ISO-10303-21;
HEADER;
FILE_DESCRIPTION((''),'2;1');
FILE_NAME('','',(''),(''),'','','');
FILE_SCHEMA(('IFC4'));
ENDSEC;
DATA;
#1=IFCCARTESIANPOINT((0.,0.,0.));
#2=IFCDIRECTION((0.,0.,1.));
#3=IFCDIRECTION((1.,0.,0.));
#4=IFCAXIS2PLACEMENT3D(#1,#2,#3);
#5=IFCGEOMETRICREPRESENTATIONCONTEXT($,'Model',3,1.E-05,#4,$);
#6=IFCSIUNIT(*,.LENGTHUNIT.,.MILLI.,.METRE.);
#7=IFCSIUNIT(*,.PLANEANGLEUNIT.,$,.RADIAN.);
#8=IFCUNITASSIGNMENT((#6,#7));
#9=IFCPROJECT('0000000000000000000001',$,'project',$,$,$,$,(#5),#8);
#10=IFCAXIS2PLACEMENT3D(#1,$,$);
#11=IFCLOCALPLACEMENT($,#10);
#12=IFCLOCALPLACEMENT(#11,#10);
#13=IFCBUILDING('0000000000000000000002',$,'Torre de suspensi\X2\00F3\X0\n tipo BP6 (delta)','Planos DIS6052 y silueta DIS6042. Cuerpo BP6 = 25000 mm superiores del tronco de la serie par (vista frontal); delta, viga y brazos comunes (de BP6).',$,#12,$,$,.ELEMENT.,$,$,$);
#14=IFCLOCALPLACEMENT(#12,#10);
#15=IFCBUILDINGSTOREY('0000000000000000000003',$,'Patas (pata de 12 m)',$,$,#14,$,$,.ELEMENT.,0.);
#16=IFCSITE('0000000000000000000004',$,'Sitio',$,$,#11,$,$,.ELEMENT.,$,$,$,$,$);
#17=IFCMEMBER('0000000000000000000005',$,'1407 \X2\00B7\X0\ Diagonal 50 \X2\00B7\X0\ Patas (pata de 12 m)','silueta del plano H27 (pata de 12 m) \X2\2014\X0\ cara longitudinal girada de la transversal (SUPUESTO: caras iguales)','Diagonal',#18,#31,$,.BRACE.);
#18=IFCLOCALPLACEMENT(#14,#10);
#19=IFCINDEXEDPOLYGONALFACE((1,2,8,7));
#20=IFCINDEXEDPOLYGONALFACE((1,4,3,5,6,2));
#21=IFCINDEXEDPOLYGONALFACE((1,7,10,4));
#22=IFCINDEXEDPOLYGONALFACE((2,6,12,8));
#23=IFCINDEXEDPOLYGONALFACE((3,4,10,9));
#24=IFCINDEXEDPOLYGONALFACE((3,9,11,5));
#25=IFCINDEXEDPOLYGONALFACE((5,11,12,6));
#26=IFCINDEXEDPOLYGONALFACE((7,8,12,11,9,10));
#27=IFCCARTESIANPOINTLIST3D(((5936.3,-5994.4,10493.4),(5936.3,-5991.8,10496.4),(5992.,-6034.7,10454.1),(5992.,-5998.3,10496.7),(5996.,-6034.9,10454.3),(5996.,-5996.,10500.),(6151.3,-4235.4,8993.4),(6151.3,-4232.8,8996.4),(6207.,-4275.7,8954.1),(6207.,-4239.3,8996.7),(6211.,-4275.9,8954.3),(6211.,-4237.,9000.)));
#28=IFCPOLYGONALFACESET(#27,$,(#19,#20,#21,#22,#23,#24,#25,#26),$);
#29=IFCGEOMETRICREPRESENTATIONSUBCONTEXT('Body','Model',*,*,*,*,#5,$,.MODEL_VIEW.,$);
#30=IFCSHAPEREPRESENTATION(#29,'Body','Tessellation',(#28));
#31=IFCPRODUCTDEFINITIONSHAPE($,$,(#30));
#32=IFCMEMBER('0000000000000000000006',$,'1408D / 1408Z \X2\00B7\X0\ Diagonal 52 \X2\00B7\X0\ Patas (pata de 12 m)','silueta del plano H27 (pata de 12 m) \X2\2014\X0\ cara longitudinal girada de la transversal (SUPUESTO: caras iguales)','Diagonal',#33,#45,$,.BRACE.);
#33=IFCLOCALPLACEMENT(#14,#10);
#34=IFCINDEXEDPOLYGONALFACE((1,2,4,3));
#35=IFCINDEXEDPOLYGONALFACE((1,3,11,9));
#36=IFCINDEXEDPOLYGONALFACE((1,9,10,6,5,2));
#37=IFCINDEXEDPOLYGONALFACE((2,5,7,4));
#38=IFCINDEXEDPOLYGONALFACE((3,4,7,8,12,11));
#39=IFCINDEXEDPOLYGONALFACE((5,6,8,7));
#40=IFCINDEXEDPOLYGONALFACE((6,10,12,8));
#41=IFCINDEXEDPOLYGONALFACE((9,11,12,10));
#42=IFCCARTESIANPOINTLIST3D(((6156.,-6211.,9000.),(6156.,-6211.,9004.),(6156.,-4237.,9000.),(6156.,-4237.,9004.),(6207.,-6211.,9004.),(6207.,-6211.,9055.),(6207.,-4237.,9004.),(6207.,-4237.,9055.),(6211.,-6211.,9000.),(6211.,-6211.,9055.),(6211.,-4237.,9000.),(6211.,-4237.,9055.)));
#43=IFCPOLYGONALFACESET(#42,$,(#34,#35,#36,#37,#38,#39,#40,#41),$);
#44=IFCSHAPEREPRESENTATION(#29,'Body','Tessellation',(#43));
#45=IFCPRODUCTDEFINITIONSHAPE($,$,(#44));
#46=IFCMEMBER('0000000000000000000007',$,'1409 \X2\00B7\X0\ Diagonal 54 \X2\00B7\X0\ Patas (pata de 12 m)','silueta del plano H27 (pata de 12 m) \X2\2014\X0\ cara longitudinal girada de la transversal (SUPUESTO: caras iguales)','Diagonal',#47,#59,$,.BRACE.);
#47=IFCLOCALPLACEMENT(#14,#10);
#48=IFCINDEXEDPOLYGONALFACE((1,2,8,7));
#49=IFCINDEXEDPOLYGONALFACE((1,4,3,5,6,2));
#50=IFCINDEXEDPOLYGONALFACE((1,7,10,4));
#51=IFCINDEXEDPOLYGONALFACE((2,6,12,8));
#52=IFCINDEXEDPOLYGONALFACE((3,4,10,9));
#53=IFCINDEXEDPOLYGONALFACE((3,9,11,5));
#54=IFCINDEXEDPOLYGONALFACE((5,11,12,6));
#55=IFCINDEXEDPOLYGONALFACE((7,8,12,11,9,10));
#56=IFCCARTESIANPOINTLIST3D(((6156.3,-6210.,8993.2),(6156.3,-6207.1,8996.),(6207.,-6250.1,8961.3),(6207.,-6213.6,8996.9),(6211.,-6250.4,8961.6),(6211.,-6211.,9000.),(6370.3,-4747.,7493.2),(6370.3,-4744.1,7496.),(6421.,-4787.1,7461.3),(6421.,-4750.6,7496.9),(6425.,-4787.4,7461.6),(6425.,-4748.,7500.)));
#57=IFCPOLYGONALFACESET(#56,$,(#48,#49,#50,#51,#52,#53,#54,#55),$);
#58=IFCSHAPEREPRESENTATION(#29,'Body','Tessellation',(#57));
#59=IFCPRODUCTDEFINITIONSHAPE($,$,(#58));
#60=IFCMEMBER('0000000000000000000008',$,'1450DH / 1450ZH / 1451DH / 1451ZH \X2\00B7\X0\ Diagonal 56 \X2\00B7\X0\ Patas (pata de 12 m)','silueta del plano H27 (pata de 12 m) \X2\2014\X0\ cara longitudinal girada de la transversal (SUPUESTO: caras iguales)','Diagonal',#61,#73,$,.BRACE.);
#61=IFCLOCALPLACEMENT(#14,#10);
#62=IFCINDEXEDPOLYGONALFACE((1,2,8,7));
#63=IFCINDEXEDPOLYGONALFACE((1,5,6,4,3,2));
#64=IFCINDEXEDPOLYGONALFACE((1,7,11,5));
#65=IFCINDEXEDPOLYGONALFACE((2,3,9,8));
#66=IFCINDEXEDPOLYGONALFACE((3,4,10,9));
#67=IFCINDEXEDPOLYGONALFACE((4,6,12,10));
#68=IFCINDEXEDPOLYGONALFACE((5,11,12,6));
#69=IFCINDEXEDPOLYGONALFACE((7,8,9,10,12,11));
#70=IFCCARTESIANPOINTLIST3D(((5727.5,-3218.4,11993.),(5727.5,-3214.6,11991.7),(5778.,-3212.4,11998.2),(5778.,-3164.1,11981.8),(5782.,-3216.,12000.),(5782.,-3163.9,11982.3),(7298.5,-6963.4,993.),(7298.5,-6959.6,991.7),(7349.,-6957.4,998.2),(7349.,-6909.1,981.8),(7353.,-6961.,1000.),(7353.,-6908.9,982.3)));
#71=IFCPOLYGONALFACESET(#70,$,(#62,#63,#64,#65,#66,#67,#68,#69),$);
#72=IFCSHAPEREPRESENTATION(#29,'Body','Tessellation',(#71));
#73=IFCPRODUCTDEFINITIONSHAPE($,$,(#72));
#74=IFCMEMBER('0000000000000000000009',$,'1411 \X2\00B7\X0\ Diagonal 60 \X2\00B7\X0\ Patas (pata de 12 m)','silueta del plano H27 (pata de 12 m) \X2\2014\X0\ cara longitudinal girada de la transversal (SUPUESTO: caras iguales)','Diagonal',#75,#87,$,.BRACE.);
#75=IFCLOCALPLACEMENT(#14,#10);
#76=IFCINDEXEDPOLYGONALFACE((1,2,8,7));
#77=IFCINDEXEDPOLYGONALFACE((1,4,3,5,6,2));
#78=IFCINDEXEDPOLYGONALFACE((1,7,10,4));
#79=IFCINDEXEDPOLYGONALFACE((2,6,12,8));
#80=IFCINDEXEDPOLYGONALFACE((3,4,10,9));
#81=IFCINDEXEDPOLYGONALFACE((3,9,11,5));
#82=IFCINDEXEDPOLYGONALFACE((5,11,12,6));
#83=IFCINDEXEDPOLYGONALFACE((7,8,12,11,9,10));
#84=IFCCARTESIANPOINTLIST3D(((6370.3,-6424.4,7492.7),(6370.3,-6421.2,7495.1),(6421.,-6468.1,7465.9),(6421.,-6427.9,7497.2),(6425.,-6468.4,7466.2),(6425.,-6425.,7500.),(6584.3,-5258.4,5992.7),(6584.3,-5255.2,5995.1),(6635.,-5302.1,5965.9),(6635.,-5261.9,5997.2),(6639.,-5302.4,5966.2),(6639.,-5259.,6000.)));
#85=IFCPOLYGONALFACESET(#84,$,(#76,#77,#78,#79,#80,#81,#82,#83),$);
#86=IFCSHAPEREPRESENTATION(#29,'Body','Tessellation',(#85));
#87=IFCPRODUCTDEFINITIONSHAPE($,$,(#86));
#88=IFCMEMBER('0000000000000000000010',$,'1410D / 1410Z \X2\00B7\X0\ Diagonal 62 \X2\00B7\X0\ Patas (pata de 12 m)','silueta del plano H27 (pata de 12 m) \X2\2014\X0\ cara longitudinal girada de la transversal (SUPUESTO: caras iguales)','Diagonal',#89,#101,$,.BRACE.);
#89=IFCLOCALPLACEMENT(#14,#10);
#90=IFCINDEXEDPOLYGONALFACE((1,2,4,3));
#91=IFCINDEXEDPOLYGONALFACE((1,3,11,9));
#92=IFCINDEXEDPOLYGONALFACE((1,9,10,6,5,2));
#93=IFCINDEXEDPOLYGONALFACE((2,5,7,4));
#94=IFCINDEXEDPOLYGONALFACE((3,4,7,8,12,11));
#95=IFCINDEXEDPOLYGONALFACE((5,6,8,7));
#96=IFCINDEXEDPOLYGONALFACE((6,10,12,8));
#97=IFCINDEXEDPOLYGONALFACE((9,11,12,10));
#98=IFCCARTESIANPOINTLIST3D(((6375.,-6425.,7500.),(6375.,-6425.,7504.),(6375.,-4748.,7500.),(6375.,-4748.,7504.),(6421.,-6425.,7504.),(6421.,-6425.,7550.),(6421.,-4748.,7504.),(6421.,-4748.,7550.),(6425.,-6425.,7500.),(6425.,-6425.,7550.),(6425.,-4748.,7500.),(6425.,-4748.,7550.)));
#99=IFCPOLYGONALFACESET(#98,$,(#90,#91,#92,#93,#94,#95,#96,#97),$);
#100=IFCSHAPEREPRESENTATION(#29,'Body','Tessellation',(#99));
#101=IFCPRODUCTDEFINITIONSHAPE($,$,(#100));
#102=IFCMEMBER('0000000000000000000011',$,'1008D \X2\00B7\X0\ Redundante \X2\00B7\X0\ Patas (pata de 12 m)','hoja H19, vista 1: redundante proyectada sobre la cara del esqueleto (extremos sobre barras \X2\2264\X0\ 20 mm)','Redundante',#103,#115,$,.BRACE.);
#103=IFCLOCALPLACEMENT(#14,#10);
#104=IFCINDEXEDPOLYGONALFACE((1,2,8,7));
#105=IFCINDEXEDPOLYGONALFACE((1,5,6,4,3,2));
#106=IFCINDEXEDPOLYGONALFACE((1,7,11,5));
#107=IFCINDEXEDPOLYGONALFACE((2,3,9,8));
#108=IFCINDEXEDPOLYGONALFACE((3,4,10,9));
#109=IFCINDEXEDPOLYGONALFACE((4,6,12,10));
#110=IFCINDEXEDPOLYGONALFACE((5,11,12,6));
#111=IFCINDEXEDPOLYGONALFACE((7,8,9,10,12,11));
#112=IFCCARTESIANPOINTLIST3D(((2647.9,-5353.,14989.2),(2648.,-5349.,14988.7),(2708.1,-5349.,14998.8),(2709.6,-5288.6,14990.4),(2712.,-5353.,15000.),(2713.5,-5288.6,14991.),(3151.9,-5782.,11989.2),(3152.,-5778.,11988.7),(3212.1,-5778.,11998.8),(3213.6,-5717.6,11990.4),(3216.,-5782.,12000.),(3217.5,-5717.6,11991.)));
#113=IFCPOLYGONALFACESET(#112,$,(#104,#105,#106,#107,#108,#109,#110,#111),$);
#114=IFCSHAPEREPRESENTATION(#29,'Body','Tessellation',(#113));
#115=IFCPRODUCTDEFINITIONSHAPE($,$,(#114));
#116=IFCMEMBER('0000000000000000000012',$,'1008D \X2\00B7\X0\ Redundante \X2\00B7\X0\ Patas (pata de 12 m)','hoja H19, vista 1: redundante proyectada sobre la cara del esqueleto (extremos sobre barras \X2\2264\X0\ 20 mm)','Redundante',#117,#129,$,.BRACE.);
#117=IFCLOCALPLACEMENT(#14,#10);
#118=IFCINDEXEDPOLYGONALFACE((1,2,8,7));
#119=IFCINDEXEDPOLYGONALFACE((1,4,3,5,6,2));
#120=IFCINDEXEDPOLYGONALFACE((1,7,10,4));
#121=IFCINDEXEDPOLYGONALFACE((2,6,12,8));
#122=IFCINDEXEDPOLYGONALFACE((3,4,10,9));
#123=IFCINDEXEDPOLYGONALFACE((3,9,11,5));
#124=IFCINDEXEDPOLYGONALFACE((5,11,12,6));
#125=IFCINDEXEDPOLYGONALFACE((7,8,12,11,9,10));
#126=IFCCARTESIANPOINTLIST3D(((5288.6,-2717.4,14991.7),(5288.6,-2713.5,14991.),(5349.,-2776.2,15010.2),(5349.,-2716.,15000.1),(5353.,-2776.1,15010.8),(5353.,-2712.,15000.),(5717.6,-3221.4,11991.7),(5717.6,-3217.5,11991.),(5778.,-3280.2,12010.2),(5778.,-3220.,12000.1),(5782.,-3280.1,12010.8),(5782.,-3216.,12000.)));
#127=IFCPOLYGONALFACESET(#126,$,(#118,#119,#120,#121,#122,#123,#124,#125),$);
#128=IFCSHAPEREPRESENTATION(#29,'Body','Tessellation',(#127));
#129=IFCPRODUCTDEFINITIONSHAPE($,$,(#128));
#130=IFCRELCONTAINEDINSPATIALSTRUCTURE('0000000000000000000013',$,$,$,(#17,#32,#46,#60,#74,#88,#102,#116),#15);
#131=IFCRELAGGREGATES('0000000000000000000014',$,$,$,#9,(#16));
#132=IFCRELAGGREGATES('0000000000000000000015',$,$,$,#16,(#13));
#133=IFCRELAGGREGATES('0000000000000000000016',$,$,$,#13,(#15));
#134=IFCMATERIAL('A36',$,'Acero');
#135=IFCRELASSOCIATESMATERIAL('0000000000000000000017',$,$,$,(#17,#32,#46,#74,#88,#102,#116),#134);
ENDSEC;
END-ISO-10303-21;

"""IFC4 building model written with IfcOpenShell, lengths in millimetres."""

from ifc_helpers import new_model, si_unit, frame, frame_2d, origin, origin_with_axes, place, context, subcontext, project, spatial, l_section, extrude, material, element, save


model = new_model("IFC4")

# Units and contexts
model_context = context("Model", 3, precision=1e-05, world=origin_with_axes())
body_context = subcontext(model_context, "Body", "Model", "MODEL_VIEW")
ifc_project = project(units=[si_unit("LENGTHUNIT", "METRE", prefix="MILLI"), si_unit("PLANEANGLEUNIT", "RADIAN")], contexts=[model_context])

# Site, building, storey
site_placement = place(None, origin())
site = spatial("IfcSite", under=ifc_project, at=site_placement, Name="Sitio", CompositionType="ELEMENT")
building_placement = place(site_placement, origin())
building = spatial("IfcBuilding", under=site, at=building_placement, Name="Torre de suspensión tipo BP6 (delta)", Description="Planos DIS6052 y silueta DIS6042. Cuerpo BP6 = 25000 mm superiores del tronco de la serie par (vista frontal); delta, viga y brazos comunes (de BP6).", CompositionType="ELEMENT")
storey_placement = place(building_placement, origin())
storey = spatial("IfcBuildingStorey", under=building, at=storey_placement, Name="Patas (pata de 12 m)", CompositionType="ELEMENT", Elevation=0.0)

# Members
ifc_material_1 = material(Name="A36", Category="Acero")
member_1_placement = place(storey_placement, frame((6211.0, -4237.0, 9000.0), z_axis=(-0.092604, -0.757633, 0.646077), x_axis=(-0.995703, 0.070463, -0.060088)))
element("IfcMember", 1, at=member_1_placement, inside=storey, material=ifc_material_1, Name="1407 · Diagonal 50 · Patas (pata de 12 m)", Description="silueta del plano H27 (pata de 12 m) — cara longitudinal girada de la transversal (SUPUESTO: caras iguales)", ObjectType="Diagonal", PredefinedType="BRACE", context=body_context, shape_type="SweptSolid", body=[
    extrude(l_section(Depth=60.0, Width=60.0, Thickness=4.0, at=frame_2d((30.0, 30.0))), None, (0.0, 0.0, 1.0), 2321.7),
])
member_2_placement = place(storey_placement, frame((6211.0, -6211.0, 9000.0), z_axis=(0.0, 1.0, 0.0), x_axis=(-1.0, 0.0, 0.0)))
element("IfcMember", 2, at=member_2_placement, inside=storey, material=ifc_material_1, Name="1408D / 1408Z · Diagonal 52 · Patas (pata de 12 m)", Description="silueta del plano H27 (pata de 12 m) — cara longitudinal girada de la transversal (SUPUESTO: caras iguales)", ObjectType="Diagonal", PredefinedType="BRACE", context=body_context, shape_type="SweptSolid", body=[
    extrude(l_section(Depth=55.0, Width=55.0, Thickness=4.0, at=frame_2d((27.5, 27.5))), None, (0.0, 0.0, 1.0), 1974.0),
])
member_3_placement = place(storey_placement, frame((6425.0, -4748.0, 7500.0), z_axis=(-0.101604, -0.694609, 0.712176), x_axis=(-0.994825, 0.070942, -0.072736)))
element("IfcMember", 3, at=member_3_placement, inside=storey, material=ifc_material_1, Name="1409 · Diagonal 54 · Patas (pata de 12 m)", Description="silueta del plano H27 (pata de 12 m) — cara longitudinal girada de la transversal (SUPUESTO: caras iguales)", ObjectType="Diagonal", PredefinedType="BRACE", context=body_context, shape_type="SweptSolid", body=[
    extrude(l_section(Depth=55.0, Width=55.0, Thickness=4.0, at=frame_2d((27.5, 27.5))), None, (0.0, 0.0, 1.0), 2106.2),
])
member_4_placement = place(storey_placement, frame((5782.0, -3216.0, 12000.0), z_axis=(0.133979, -0.319383, -0.938107), x_axis=(-0.990984, -0.04318, -0.12683)))
element("IfcMember", 4, at=member_4_placement, inside=storey, Name="1450DH / 1450ZH / 1451DH / 1451ZH · Diagonal 56 · Patas (pata de 12 m)", Description="silueta del plano H27 (pata de 12 m) — cara longitudinal girada de la transversal (SUPUESTO: caras iguales)", ObjectType="Diagonal", PredefinedType="BRACE", context=body_context, shape_type="SweptSolid", body=[
    extrude(l_section(Depth=55.0, Width=55.0, Thickness=4.0, at=frame_2d((27.5, 27.5))), None, (0.0, 0.0, 1.0), 11725.7),
])
member_5_placement = place(storey_placement, frame((6639.0, -5259.0, 6000.0), z_axis=(-0.111931, -0.609865, 0.784561), x_axis=(-0.993716, 0.068694, -0.088372)))
element("IfcMember", 5, at=member_5_placement, inside=storey, material=ifc_material_1, Name="1411 · Diagonal 60 · Patas (pata de 12 m)", Description="silueta del plano H27 (pata de 12 m) — cara longitudinal girada de la transversal (SUPUESTO: caras iguales)", ObjectType="Diagonal", PredefinedType="BRACE", context=body_context, shape_type="SweptSolid", body=[
    extrude(l_section(Depth=55.0, Width=55.0, Thickness=4.0, at=frame_2d((27.5, 27.5))), None, (0.0, 0.0, 1.0), 1911.9),
])
member_6_placement = place(storey_placement, frame((6425.0, -6425.0, 7500.0), z_axis=(0.0, 1.0, 0.0), x_axis=(-1.0, 0.0, 0.0)))
element("IfcMember", 6, at=member_6_placement, inside=storey, material=ifc_material_1, Name="1410D / 1410Z · Diagonal 62 · Patas (pata de 12 m)", Description="silueta del plano H27 (pata de 12 m) — cara longitudinal girada de la transversal (SUPUESTO: caras iguales)", ObjectType="Diagonal", PredefinedType="BRACE", context=body_context, shape_type="SweptSolid", body=[
    extrude(l_section(Depth=50.0, Width=50.0, Thickness=4.0, at=frame_2d((25.0, 25.0))), None, (0.0, 0.0, 1.0), 1677.0),
])
for number, where, z_axis, x_axis, name in (
    (7, (3216.0, -5782.0, 12000.0), (-0.164055, 0.139642, 0.976517), (0.023136, 0.990202, -0.137712), "1008D · Redundante · Patas (pata de 12 m)"),
    (8, (5782.0, -3216.0, 12000.0), (-0.139642, 0.164055, 0.976517), (-0.990202, -0.023136, -0.137712), "1008D · Redundante · Patas (pata de 12 m)"),
):
    element("IfcMember", number, at=place(storey_placement, frame(where, z_axis=z_axis, x_axis=x_axis)), inside=storey, material=ifc_material_1, Name=name, Description="hoja H19, vista 1: redundante proyectada sobre la cara del esqueleto (extremos sobre barras ≤ 20 mm)", ObjectType="Redundante", PredefinedType="BRACE", context=body_context, shape_type="SweptSolid", body=[
        extrude(l_section(Depth=65.0, Width=65.0, Thickness=4.0, at=frame_2d((32.5, 32.5))), None, (0.0, 0.0, 1.0), 3072.1),
    ])

save(model, "model.ifc")
